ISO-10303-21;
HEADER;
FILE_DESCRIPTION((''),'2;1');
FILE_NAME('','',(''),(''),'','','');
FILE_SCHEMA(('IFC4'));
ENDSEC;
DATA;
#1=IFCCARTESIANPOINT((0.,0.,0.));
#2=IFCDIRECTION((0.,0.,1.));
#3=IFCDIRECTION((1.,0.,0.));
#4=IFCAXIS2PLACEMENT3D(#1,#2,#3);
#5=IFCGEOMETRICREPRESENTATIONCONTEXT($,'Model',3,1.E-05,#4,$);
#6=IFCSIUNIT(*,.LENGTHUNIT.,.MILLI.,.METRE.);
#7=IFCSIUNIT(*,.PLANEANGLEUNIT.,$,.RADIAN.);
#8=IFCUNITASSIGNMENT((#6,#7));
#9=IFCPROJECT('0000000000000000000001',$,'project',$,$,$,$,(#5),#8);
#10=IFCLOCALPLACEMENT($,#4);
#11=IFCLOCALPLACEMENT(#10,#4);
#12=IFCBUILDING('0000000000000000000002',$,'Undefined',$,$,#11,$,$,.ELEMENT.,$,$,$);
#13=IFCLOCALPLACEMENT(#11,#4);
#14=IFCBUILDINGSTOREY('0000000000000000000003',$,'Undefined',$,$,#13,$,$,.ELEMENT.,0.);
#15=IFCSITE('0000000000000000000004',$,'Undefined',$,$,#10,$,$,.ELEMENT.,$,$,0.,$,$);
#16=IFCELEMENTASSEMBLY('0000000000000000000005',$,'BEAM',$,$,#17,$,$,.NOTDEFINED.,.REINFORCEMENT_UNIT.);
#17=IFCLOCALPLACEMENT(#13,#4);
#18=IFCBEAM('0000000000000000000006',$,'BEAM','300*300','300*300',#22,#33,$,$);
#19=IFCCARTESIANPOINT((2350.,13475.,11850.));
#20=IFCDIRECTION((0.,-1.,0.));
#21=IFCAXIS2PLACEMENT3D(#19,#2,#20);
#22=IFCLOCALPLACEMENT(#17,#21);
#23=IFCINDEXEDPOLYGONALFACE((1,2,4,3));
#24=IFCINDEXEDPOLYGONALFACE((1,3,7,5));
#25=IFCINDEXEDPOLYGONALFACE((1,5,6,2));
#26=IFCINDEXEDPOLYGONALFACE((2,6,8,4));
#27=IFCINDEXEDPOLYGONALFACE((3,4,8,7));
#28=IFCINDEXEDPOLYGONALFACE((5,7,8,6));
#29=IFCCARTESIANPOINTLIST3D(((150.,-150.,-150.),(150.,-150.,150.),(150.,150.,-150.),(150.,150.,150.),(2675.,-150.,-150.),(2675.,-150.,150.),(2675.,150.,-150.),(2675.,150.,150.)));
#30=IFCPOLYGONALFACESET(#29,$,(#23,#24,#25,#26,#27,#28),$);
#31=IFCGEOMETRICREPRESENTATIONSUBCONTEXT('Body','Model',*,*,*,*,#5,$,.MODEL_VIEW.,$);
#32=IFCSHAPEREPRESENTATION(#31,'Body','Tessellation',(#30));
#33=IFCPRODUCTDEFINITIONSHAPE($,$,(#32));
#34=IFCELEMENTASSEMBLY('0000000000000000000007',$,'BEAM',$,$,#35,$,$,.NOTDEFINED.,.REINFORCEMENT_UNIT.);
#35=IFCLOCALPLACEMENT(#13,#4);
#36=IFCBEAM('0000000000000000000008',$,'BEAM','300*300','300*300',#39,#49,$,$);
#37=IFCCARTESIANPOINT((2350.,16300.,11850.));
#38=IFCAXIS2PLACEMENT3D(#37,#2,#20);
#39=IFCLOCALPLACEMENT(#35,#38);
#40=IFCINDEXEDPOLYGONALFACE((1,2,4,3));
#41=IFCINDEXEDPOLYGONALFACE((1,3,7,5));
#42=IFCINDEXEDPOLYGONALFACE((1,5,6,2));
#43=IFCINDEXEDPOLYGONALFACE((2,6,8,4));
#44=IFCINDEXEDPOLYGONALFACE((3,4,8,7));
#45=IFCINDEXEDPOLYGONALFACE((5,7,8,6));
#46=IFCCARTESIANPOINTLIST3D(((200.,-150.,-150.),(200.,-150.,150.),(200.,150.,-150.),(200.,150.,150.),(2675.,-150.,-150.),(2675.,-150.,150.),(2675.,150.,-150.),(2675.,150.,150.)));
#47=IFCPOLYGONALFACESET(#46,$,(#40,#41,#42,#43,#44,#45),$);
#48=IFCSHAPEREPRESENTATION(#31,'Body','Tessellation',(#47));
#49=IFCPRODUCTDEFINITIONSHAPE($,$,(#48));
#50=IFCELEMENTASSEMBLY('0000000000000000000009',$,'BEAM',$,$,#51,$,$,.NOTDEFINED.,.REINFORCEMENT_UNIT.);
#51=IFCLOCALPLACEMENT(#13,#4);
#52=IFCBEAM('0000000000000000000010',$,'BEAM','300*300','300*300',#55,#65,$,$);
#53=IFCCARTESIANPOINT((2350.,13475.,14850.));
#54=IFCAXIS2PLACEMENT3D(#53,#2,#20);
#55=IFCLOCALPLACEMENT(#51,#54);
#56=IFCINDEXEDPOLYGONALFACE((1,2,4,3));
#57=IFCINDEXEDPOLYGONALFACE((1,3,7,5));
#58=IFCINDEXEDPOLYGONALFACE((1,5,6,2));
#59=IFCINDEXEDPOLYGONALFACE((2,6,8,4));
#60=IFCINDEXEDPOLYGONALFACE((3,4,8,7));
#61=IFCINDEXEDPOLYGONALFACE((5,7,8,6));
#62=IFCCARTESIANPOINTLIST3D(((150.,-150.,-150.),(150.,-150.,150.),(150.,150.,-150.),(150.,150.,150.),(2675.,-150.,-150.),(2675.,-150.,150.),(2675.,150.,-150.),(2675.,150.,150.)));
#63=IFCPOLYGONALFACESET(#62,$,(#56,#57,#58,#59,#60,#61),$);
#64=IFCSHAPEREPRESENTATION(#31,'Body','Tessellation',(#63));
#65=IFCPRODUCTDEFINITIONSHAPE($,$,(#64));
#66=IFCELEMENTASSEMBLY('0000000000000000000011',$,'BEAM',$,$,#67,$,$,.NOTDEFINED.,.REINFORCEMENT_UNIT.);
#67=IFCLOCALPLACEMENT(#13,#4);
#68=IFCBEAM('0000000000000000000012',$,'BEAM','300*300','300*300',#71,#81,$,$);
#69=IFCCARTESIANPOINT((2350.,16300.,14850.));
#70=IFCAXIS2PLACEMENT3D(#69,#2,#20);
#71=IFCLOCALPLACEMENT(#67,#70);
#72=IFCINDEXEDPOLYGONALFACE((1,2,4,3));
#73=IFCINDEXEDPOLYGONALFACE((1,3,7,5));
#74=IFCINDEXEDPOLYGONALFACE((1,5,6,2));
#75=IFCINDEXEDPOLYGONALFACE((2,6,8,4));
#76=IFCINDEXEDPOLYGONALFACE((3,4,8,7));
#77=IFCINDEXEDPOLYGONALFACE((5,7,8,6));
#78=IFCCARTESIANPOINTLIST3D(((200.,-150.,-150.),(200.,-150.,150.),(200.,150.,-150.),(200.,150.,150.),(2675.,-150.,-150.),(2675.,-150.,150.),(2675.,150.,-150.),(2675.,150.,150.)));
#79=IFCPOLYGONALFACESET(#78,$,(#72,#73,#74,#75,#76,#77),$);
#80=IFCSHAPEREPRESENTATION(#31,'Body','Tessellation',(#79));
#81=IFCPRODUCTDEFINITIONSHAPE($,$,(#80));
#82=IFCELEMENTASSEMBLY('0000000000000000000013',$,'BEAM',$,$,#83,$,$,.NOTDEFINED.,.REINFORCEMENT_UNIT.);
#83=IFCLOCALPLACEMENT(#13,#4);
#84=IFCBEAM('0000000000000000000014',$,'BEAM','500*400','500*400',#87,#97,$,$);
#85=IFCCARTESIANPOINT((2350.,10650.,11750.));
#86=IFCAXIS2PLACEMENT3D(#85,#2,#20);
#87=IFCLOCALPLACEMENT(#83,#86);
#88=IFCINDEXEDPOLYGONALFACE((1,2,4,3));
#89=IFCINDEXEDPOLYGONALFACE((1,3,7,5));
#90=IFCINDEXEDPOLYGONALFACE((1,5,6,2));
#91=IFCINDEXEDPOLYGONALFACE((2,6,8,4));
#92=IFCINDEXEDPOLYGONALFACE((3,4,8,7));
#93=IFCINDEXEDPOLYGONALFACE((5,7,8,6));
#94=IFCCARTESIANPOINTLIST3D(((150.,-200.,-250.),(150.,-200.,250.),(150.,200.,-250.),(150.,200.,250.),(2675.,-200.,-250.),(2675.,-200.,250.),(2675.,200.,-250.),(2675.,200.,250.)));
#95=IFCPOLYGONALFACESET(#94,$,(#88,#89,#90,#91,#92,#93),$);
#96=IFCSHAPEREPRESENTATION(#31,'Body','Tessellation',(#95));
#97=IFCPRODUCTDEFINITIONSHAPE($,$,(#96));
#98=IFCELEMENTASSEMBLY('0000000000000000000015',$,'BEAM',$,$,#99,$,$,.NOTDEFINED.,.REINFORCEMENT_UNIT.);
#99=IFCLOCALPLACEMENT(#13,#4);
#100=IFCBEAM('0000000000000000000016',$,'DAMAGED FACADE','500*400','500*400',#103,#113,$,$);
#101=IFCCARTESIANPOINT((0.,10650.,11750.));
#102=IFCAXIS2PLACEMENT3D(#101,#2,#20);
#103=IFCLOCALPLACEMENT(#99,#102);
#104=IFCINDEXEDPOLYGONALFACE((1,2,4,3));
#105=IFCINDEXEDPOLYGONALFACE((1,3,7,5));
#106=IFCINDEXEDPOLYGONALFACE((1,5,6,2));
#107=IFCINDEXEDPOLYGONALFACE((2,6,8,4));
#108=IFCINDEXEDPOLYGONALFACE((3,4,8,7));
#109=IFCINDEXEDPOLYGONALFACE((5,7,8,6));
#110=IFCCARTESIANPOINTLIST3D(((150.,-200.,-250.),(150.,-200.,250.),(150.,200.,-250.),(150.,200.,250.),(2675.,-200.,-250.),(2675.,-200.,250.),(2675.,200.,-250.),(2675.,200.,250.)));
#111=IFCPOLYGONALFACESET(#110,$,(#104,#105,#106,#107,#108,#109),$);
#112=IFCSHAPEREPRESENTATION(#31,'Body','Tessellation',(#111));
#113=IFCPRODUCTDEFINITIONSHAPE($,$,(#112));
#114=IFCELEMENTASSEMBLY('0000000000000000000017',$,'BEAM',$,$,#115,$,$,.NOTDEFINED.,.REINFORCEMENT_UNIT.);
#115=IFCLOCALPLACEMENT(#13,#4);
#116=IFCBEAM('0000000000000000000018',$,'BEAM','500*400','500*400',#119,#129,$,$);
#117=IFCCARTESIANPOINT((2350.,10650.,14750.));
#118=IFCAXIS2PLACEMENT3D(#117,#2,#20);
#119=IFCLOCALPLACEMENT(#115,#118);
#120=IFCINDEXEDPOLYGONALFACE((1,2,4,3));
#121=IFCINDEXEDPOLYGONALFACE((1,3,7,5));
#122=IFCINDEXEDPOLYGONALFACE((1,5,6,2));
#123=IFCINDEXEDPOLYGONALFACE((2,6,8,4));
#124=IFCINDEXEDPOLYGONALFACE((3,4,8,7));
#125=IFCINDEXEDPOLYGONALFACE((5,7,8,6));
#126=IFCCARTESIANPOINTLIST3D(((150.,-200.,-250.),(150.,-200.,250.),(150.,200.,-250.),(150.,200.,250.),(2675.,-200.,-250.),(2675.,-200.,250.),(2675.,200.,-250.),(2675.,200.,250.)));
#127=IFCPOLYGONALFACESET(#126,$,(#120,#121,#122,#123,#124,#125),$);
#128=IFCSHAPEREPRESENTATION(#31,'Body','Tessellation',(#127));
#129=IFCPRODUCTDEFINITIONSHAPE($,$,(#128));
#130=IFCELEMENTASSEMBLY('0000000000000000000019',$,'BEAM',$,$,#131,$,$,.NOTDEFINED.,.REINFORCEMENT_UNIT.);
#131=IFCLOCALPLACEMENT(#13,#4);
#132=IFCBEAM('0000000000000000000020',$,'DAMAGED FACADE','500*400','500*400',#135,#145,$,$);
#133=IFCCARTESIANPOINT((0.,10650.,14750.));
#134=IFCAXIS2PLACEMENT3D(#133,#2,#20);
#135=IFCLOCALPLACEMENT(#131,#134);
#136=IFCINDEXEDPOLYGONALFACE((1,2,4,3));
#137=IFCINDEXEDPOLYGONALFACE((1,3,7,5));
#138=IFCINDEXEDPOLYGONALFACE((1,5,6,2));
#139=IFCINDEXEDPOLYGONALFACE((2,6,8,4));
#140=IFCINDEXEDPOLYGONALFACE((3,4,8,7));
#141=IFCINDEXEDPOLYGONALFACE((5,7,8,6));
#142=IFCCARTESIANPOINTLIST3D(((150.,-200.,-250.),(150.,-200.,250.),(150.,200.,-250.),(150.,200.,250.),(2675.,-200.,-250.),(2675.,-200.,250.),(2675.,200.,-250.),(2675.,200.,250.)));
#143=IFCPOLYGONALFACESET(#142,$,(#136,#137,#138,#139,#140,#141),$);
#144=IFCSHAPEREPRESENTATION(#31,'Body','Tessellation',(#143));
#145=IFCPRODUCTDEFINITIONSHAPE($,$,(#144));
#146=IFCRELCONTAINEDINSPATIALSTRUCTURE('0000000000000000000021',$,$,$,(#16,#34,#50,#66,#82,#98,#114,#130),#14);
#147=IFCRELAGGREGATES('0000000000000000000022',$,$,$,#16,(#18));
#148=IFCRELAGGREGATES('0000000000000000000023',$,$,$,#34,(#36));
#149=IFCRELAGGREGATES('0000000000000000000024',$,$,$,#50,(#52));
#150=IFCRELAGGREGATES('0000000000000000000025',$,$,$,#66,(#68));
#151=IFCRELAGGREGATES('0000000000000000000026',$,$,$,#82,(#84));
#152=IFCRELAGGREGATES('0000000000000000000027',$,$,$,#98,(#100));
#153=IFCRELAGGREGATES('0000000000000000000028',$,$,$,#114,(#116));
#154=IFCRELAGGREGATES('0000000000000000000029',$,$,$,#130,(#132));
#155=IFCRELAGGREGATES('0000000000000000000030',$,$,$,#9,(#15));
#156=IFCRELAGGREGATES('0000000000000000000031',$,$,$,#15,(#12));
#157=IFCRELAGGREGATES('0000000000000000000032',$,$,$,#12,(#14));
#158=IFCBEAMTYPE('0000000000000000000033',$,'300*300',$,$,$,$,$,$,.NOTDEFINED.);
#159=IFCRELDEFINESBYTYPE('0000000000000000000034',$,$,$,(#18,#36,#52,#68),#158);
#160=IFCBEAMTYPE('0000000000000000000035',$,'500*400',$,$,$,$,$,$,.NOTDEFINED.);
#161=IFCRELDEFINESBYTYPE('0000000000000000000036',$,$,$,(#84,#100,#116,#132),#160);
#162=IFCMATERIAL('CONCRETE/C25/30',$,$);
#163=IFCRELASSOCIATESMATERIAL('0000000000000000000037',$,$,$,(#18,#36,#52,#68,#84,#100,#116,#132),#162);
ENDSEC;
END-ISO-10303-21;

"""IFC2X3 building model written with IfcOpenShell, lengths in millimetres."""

from ifc_helpers import new_model, si_unit, frame, origin_with_axes, origin_2d_with_axis, place, context, subcontext, project, spatial, rectangle, extrude, material, type_object, element, aggregate, save


model = new_model("IFC2X3")

# Units and contexts
model_context = context("Model", 3, precision=1e-05, world=origin_with_axes())
body_context = subcontext(model_context, "Body", "Model", "MODEL_VIEW")
ifc_project = project(units=[si_unit("LENGTHUNIT", "METRE", prefix="MILLI"), si_unit("PLANEANGLEUNIT", "RADIAN")], contexts=[model_context])

# Site, building, storey
site_placement = place(None, origin_with_axes())
site = spatial("IfcSite", under=ifc_project, at=site_placement, Name="Undefined", CompositionType="ELEMENT", RefElevation=0.0)
building_placement = place(site_placement, origin_with_axes())
building = spatial("IfcBuilding", under=site, at=building_placement, Name="Undefined", CompositionType="ELEMENT")
storey_placement = place(building_placement, origin_with_axes())
storey = spatial("IfcBuildingStorey", under=building, at=storey_placement, Name="Undefined", CompositionType="ELEMENT", Elevation=0.0)

# Shared definitions
ifc_material = material(Name="CONCRETE/C25/30")

# Element assemblies, beams
assembly_1_placement = place(storey_placement, origin_with_axes())
assembly_1 = element("IfcElementAssembly", 1, at=assembly_1_placement, inside=storey, Name="BEAM", AssemblyPlace="NOTDEFINED", PredefinedType="REINFORCEMENT_UNIT")
beam_type_1 = type_object("IfcBeamType", Name="300*300", PredefinedType="NOTDEFINED")
beam_1_placement = place(assembly_1_placement, frame((2350.0, 13475.0, 11850.0), z_axis=(0.0, 0.0, 1.0), x_axis=(0.0, -1.0, 0.0)))
beam_1 = element("IfcBeam", 2, at=beam_1_placement, type_object=beam_type_1, material=ifc_material, Name="BEAM", Description="300*300", ObjectType="300*300", context=body_context, shape_type="SweptSolid", body=[
    extrude(rectangle(XDim=300.0, YDim=300.0, at=origin_2d_with_axis()), frame((2675.0, 0.0, 0.0), z_axis=(-1.0, 0.0, 0.0), x_axis=(0.0, -1.0, 0.0)), (0.0, 0.0, 1.0), 2525.0),
])
aggregate(assembly_1, [beam_1])
assembly_2_placement = place(storey_placement, origin_with_axes())
assembly_2 = element("IfcElementAssembly", 3, at=assembly_2_placement, inside=storey, Name="BEAM", AssemblyPlace="NOTDEFINED", PredefinedType="REINFORCEMENT_UNIT")
beam_2_placement = place(assembly_2_placement, frame((2350.0, 16300.0, 11850.0), z_axis=(0.0, 0.0, 1.0), x_axis=(0.0, -1.0, 0.0)))
beam_2 = element("IfcBeam", 4, at=beam_2_placement, type_object=beam_type_1, material=ifc_material, Name="BEAM", Description="300*300", ObjectType="300*300", context=body_context, shape_type="SweptSolid", body=[
    extrude(rectangle(XDim=300.0, YDim=300.0, at=origin_2d_with_axis()), frame((2675.0, 0.0, 0.0), z_axis=(-1.0, 0.0, 0.0), x_axis=(0.0, -1.0, 0.0)), (0.0, 0.0, 1.0), 2475.0),
])
aggregate(assembly_2, [beam_2])
assembly_3_placement = place(storey_placement, origin_with_axes())
assembly_3 = element("IfcElementAssembly", 5, at=assembly_3_placement, inside=storey, Name="BEAM", AssemblyPlace="NOTDEFINED", PredefinedType="REINFORCEMENT_UNIT")
beam_3_placement = place(assembly_3_placement, frame((2350.0, 13475.0, 14850.0), z_axis=(0.0, 0.0, 1.0), x_axis=(0.0, -1.0, 0.0)))
beam_3 = element("IfcBeam", 6, at=beam_3_placement, type_object=beam_type_1, material=ifc_material, Name="BEAM", Description="300*300", ObjectType="300*300", context=body_context, shape_type="SweptSolid", body=[
    extrude(rectangle(XDim=300.0, YDim=300.0, at=origin_2d_with_axis()), frame((2675.0, 0.0, 0.0), z_axis=(-1.0, 0.0, 0.0), x_axis=(0.0, -1.0, 0.0)), (0.0, 0.0, 1.0), 2525.0),
])
aggregate(assembly_3, [beam_3])
assembly_4_placement = place(storey_placement, origin_with_axes())
assembly_4 = element("IfcElementAssembly", 7, at=assembly_4_placement, inside=storey, Name="BEAM", AssemblyPlace="NOTDEFINED", PredefinedType="REINFORCEMENT_UNIT")
beam_4_placement = place(assembly_4_placement, frame((2350.0, 16300.0, 14850.0), z_axis=(0.0, 0.0, 1.0), x_axis=(0.0, -1.0, 0.0)))
beam_4 = element("IfcBeam", 8, at=beam_4_placement, type_object=beam_type_1, material=ifc_material, Name="BEAM", Description="300*300", ObjectType="300*300", context=body_context, shape_type="SweptSolid", body=[
    extrude(rectangle(XDim=300.0, YDim=300.0, at=origin_2d_with_axis()), frame((2675.0, 0.0, 0.0), z_axis=(-1.0, 0.0, 0.0), x_axis=(0.0, -1.0, 0.0)), (0.0, 0.0, 1.0), 2475.0),
])
aggregate(assembly_4, [beam_4])
assembly_5_placement = place(storey_placement, origin_with_axes())
assembly_5 = element("IfcElementAssembly", 9, at=assembly_5_placement, inside=storey, Name="BEAM", AssemblyPlace="NOTDEFINED", PredefinedType="REINFORCEMENT_UNIT")
beam_type_2 = type_object("IfcBeamType", Name="500*400", PredefinedType="NOTDEFINED")
beam_5_placement = place(assembly_5_placement, frame((2350.0, 10650.0, 11750.0), z_axis=(0.0, 0.0, 1.0), x_axis=(0.0, -1.0, 0.0)))
beam_5 = element("IfcBeam", 10, at=beam_5_placement, type_object=beam_type_2, material=ifc_material, Name="BEAM", Description="500*400", ObjectType="500*400", context=body_context, shape_type="SweptSolid", body=[
    extrude(rectangle(XDim=400.0, YDim=500.0, at=origin_2d_with_axis()), frame((2675.0, 0.0, 0.0), z_axis=(-1.0, 0.0, 0.0), x_axis=(0.0, -1.0, 0.0)), (0.0, 0.0, 1.0), 2525.0),
])
aggregate(assembly_5, [beam_5])
assembly_6_placement = place(storey_placement, origin_with_axes())
assembly_6 = element("IfcElementAssembly", 11, at=assembly_6_placement, inside=storey, Name="BEAM", AssemblyPlace="NOTDEFINED", PredefinedType="REINFORCEMENT_UNIT")
beam_6_placement = place(assembly_6_placement, frame((0.0, 10650.0, 11750.0), z_axis=(0.0, 0.0, 1.0), x_axis=(0.0, -1.0, 0.0)))
beam_6 = element("IfcBeam", 12, at=beam_6_placement, type_object=beam_type_2, material=ifc_material, Name="DAMAGED FACADE", Description="500*400", ObjectType="500*400", context=body_context, shape_type="SweptSolid", body=[
    extrude(rectangle(XDim=400.0, YDim=500.0, at=origin_2d_with_axis()), frame((2675.0, 0.0, 0.0), z_axis=(-1.0, 0.0, 0.0), x_axis=(0.0, -1.0, 0.0)), (0.0, 0.0, 1.0), 2525.0),
])
aggregate(assembly_6, [beam_6])
assembly_7_placement = place(storey_placement, origin_with_axes())
assembly_7 = element("IfcElementAssembly", 13, at=assembly_7_placement, inside=storey, Name="BEAM", AssemblyPlace="NOTDEFINED", PredefinedType="REINFORCEMENT_UNIT")
beam_7_placement = place(assembly_7_placement, frame((2350.0, 10650.0, 14750.0), z_axis=(0.0, 0.0, 1.0), x_axis=(0.0, -1.0, 0.0)))
beam_7 = element("IfcBeam", 14, at=beam_7_placement, type_object=beam_type_2, material=ifc_material, Name="BEAM", Description="500*400", ObjectType="500*400", context=body_context, shape_type="SweptSolid", body=[
    extrude(rectangle(XDim=400.0, YDim=500.0, at=origin_2d_with_axis()), frame((2675.0, 0.0, 0.0), z_axis=(-1.0, 0.0, 0.0), x_axis=(0.0, -1.0, 0.0)), (0.0, 0.0, 1.0), 2525.0),
])
aggregate(assembly_7, [beam_7])
assembly_8_placement = place(storey_placement, origin_with_axes())
assembly_8 = element("IfcElementAssembly", 15, at=assembly_8_placement, inside=storey, Name="BEAM", AssemblyPlace="NOTDEFINED", PredefinedType="REINFORCEMENT_UNIT")
beam_8_placement = place(assembly_8_placement, frame((0.0, 10650.0, 14750.0), z_axis=(0.0, 0.0, 1.0), x_axis=(0.0, -1.0, 0.0)))
beam_8 = element("IfcBeam", 16, at=beam_8_placement, type_object=beam_type_2, material=ifc_material, Name="DAMAGED FACADE", Description="500*400", ObjectType="500*400", context=body_context, shape_type="SweptSolid", body=[
    extrude(rectangle(XDim=400.0, YDim=500.0, at=origin_2d_with_axis()), frame((2675.0, 0.0, 0.0), z_axis=(-1.0, 0.0, 0.0), x_axis=(0.0, -1.0, 0.0)), (0.0, 0.0, 1.0), 2525.0),
])
aggregate(assembly_8, [beam_8])

save(model, "model.ifc")
